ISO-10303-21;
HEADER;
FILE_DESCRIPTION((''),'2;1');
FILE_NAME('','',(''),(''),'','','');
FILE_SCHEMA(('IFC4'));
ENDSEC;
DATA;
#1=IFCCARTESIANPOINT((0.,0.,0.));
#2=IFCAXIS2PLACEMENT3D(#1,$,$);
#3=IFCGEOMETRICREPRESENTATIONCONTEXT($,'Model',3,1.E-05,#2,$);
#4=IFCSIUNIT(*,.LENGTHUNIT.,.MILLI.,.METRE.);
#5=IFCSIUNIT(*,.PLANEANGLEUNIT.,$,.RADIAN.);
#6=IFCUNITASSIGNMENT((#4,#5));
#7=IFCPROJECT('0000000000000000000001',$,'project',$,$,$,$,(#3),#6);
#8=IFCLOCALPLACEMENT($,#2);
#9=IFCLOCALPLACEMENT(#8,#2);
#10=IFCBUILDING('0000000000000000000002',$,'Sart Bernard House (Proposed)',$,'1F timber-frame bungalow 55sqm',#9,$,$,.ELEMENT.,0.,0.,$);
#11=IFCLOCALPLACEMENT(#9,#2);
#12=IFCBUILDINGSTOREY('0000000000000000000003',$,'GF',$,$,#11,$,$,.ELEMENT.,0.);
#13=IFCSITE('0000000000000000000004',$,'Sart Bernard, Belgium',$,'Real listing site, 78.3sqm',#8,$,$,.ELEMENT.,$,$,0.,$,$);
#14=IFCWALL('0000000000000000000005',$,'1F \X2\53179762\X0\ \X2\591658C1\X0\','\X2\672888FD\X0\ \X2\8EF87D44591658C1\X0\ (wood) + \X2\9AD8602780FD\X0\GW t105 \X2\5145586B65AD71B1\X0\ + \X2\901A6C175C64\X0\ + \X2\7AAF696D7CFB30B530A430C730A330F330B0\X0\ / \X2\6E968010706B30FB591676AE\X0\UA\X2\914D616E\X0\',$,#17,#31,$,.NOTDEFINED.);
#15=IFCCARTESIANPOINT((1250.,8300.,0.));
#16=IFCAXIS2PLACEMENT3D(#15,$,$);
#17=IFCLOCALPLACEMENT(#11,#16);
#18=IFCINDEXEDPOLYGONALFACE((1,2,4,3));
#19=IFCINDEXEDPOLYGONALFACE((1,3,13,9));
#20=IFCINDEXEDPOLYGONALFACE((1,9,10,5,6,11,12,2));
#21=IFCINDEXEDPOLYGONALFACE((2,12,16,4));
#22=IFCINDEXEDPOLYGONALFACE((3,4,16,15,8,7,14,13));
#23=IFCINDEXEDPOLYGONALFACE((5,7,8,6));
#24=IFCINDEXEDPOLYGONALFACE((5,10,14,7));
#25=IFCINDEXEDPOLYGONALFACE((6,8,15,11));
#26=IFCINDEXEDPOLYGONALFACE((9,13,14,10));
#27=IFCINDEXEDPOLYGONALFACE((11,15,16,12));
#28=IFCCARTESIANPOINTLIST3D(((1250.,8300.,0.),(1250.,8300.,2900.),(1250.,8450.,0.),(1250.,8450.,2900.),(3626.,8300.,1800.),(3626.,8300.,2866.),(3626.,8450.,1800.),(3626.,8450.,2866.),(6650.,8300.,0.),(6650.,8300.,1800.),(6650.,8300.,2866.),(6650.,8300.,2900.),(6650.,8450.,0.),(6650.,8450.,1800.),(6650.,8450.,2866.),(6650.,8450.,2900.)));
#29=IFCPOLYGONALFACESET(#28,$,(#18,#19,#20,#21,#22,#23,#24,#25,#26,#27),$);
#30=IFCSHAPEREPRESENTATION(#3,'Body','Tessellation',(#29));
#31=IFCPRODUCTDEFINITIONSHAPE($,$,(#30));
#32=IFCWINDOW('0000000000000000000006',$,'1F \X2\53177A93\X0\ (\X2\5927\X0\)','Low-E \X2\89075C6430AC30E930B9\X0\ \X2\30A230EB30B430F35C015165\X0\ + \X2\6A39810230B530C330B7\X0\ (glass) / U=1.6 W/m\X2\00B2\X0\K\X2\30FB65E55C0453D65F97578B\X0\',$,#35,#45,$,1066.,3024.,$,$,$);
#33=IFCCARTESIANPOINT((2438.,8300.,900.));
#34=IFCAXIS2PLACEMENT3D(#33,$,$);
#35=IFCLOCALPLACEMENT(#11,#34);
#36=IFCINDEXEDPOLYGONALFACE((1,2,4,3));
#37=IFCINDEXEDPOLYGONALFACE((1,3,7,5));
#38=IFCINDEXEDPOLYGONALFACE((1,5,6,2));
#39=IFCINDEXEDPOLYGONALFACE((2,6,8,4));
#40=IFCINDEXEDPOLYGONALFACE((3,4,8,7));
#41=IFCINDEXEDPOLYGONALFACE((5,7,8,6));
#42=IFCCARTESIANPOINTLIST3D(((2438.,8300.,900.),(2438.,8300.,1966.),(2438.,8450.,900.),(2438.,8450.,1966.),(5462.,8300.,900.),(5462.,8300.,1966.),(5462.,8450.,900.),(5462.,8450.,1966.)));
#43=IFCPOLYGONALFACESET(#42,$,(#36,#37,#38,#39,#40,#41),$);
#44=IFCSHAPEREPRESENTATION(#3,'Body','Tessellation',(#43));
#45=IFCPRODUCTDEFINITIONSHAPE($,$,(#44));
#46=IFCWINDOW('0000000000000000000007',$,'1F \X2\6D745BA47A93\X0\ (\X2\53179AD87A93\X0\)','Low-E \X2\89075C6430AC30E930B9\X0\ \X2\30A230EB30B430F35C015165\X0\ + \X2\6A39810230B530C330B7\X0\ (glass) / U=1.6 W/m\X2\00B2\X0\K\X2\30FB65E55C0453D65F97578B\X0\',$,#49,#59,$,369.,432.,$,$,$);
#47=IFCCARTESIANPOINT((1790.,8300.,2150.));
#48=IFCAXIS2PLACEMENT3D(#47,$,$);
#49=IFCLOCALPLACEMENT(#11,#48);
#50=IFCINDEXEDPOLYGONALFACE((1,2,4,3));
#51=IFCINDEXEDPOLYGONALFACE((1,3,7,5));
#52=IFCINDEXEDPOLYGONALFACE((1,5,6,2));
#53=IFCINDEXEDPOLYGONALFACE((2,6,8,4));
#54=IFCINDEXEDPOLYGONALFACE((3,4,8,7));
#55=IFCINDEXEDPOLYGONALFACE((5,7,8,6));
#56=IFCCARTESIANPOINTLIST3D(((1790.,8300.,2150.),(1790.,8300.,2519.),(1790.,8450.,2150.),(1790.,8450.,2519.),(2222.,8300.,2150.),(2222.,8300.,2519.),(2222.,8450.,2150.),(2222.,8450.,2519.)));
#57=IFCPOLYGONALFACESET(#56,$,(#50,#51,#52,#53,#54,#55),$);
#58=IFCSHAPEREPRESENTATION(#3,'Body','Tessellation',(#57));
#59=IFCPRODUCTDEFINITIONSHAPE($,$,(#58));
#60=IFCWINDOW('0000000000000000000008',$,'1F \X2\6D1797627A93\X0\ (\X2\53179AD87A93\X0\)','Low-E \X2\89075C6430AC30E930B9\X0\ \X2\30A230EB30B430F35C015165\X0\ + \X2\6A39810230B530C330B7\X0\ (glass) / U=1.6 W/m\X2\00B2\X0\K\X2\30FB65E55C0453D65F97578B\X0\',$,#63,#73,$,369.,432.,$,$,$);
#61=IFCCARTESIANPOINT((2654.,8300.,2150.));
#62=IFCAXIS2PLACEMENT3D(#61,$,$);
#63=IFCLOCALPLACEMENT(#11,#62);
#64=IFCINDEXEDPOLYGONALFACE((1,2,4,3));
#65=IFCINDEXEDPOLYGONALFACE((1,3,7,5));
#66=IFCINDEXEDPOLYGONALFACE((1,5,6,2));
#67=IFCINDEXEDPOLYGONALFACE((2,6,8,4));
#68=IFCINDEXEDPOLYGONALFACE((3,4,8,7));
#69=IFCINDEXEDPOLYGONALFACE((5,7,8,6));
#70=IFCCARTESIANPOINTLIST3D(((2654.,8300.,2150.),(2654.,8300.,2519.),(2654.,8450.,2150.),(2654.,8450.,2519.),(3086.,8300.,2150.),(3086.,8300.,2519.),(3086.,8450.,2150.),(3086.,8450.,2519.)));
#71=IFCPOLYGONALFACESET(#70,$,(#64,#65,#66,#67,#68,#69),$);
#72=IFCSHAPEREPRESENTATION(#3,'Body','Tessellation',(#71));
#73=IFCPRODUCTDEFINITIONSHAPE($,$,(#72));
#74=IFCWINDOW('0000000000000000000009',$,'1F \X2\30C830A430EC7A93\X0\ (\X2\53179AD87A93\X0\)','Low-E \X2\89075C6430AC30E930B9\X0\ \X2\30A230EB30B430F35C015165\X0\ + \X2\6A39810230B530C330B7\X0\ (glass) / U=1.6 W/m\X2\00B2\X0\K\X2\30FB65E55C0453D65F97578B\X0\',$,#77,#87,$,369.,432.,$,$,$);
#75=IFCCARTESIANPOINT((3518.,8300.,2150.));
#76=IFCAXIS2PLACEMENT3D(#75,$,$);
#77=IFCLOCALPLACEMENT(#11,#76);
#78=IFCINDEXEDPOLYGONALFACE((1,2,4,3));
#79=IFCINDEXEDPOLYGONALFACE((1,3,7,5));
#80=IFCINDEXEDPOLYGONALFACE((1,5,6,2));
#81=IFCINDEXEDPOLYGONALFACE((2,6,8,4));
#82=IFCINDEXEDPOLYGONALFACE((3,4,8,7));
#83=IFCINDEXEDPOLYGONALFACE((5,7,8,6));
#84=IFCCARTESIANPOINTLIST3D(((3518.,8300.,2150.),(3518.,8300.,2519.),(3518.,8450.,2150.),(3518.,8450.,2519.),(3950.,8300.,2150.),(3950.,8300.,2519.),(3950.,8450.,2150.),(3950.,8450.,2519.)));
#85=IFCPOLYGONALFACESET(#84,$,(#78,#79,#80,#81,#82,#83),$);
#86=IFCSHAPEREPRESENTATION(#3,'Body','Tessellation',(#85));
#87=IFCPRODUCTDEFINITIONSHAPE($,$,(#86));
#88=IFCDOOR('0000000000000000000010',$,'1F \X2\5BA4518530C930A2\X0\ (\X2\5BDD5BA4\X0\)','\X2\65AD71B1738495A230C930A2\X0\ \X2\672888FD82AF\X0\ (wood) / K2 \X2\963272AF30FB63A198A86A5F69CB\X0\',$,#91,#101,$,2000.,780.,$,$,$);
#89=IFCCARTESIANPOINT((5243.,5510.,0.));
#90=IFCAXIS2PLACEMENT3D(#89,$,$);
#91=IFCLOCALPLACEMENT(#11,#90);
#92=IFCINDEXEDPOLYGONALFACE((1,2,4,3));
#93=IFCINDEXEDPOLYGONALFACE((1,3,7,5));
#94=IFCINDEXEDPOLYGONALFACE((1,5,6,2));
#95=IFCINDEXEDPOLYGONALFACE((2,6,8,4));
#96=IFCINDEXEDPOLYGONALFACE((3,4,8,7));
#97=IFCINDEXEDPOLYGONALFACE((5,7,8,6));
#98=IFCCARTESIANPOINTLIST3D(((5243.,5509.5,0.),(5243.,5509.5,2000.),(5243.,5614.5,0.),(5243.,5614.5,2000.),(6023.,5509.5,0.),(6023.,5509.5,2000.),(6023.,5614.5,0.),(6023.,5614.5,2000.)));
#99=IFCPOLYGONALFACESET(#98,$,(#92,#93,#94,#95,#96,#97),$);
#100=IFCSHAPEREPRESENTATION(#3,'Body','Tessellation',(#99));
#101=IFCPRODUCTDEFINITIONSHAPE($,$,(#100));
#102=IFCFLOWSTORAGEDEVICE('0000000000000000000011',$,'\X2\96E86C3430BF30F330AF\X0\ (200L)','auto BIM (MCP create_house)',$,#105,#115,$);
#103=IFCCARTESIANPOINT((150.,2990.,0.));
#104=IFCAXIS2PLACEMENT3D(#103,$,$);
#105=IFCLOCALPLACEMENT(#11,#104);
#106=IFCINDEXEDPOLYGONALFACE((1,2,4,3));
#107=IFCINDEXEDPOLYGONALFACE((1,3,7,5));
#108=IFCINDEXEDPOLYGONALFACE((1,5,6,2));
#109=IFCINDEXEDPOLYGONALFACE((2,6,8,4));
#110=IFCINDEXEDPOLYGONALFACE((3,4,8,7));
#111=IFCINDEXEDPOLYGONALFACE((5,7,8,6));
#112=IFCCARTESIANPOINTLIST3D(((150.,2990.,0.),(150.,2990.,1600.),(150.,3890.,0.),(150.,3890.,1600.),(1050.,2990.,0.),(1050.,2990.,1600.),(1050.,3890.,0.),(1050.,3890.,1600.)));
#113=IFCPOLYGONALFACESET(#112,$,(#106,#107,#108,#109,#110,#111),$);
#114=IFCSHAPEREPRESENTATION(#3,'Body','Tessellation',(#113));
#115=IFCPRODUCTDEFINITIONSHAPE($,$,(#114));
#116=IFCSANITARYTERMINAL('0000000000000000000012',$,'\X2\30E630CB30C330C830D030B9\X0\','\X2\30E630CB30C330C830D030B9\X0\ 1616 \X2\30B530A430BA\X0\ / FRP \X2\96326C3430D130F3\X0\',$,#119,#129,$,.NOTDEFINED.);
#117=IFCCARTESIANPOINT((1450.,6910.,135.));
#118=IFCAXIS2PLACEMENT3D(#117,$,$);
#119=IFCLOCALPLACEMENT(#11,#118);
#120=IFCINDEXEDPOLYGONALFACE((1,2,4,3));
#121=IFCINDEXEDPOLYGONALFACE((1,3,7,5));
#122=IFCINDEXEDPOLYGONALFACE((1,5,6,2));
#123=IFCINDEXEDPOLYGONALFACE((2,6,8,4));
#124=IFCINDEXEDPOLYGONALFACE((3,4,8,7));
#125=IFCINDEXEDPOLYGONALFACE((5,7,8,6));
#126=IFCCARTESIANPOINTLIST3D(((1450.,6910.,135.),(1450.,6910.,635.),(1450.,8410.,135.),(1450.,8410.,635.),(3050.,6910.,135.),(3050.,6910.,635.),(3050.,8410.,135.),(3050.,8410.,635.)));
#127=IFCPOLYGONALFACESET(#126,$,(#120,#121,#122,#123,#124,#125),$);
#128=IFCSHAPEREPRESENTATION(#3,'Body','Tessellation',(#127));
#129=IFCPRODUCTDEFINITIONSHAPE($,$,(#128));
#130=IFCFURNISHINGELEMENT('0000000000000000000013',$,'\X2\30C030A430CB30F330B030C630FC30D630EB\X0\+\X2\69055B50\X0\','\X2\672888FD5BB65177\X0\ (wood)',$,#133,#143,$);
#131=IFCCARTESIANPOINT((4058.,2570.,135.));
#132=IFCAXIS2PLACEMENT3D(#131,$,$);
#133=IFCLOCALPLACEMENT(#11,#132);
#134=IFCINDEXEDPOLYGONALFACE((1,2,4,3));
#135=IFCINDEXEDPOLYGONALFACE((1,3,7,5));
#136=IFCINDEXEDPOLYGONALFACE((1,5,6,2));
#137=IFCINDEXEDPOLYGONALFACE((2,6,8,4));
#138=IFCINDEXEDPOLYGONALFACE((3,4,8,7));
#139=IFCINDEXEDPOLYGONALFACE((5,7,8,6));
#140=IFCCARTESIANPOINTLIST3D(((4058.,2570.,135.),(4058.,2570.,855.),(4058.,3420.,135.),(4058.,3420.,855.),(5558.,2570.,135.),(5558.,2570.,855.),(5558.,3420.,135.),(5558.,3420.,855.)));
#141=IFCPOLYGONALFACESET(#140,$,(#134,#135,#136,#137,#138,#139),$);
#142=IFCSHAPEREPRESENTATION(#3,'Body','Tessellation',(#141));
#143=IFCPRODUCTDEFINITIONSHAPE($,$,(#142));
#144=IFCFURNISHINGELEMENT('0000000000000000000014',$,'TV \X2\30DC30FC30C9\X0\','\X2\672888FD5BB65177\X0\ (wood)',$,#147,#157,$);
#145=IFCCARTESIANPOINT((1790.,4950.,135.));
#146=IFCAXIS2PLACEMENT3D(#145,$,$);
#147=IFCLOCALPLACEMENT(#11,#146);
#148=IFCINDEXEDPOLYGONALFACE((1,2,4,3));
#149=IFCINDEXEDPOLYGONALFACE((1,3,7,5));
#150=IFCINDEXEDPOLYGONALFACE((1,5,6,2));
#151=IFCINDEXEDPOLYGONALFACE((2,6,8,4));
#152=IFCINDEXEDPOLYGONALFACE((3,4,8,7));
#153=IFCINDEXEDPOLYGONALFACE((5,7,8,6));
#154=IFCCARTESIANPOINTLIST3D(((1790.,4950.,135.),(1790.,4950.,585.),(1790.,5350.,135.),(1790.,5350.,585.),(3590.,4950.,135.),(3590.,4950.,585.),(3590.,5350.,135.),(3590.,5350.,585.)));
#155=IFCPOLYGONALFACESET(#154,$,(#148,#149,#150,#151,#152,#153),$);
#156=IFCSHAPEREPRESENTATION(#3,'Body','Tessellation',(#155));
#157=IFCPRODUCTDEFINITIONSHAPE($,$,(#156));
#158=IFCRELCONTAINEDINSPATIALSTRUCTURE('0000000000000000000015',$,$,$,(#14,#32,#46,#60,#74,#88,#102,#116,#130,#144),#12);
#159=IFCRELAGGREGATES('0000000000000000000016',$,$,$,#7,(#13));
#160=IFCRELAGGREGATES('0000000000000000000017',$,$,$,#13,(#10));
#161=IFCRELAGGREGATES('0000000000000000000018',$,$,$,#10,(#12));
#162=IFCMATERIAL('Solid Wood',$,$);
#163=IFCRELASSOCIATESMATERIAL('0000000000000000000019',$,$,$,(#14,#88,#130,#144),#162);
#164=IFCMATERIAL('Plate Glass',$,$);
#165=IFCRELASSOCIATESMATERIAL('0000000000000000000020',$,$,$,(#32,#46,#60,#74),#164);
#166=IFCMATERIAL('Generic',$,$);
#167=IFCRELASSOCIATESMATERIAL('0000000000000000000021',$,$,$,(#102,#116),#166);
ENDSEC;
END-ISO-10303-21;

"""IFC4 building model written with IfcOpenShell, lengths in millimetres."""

from ifc_helpers import new_model, si_unit, frame, frame_2d, origin, place, context, project, spatial, rectangle, extrude, material, element, fill, save


model = new_model("IFC4")

# Units and contexts
model_context = context("Model", 3, precision=1e-05, world=origin())
ifc_project = project(units=[si_unit("LENGTHUNIT", "METRE", prefix="MILLI"), si_unit("PLANEANGLEUNIT", "RADIAN")], contexts=[model_context])

# Site, building, storey
site_placement = place(None, origin())
site = spatial("IfcSite", under=ifc_project, at=site_placement, Name="Sart Bernard, Belgium", ObjectType="Real listing site, 78.3sqm", CompositionType="ELEMENT", RefElevation=0.0)
building_placement = place(site_placement, origin())
building = spatial("IfcBuilding", under=site, at=building_placement, Name="Sart Bernard House (Proposed)", ObjectType="1F timber-frame bungalow 55sqm", CompositionType="ELEMENT", ElevationOfRefHeight=0.0, ElevationOfTerrain=0.0)
storey_placement = place(building_placement, origin())
storey = spatial("IfcBuildingStorey", under=building, at=storey_placement, Name="GF", CompositionType="ELEMENT", Elevation=0.0)

# Wall, openings, windows
ifc_material_1 = material(Name="Solid Wood")
wall_1_placement = place(storey_placement, frame((1250.0, 8300.0, 0.0)))
wall_1 = element("IfcWall", 1, at=wall_1_placement, inside=storey, material=ifc_material_1, Name="1F 北面 外壁", Description="木製 軸組外壁 (wood) + 高性能GW t105 充填断熱 + 通気層 + 窯業系サイディング / 準耐火・外皮UA配慮", PredefinedType="NOTDEFINED", context=model_context, shape_type="SweptSolid", body=[
    extrude(rectangle(XDim=5400.0, YDim=150.0, at=frame_2d((2700.0, 75.0))), frame((1250.0, 8300.0, 0.0)), (0.0, 0.0, 1.0), 2900.0),
])
opening_1_placement = place(storey_placement, frame((2438.0, 8300.0, 900.0)))
opening_1 = element("IfcOpeningElement", 2, at=opening_1_placement, cuts=wall_1, PredefinedType="NOTDEFINED", context=model_context, shape_type="SweptSolid", body=[
    extrude(rectangle(XDim=3024.0, YDim=150.0, at=frame_2d((1512.0, 75.0))), frame((2438.0, 8300.0, 900.0)), (0.0, 0.0, 1.0), 1066.0),
])
opening_2_placement = place(storey_placement, frame((1790.0, 8300.0, 2150.0)))
opening_2 = element("IfcOpeningElement", 3, at=opening_2_placement, cuts=wall_1, PredefinedType="NOTDEFINED", context=model_context, shape_type="SweptSolid", body=[
    extrude(rectangle(XDim=432.0, YDim=150.0, at=frame_2d((216.0, 75.0))), frame((1790.0, 8300.0, 2150.0)), (0.0, 0.0, 1.0), 369.0),
])
opening_3_placement = place(storey_placement, frame((2654.0, 8300.0, 2150.0)))
opening_3 = element("IfcOpeningElement", 4, at=opening_3_placement, cuts=wall_1, PredefinedType="NOTDEFINED", context=model_context, shape_type="SweptSolid", body=[
    extrude(rectangle(XDim=432.0, YDim=150.0, at=frame_2d((216.0, 75.0))), frame((2654.0, 8300.0, 2150.0)), (0.0, 0.0, 1.0), 369.0),
])
opening_4_placement = place(storey_placement, frame((3518.0, 8300.0, 2150.0)))
opening_4 = element("IfcOpeningElement", 5, at=opening_4_placement, cuts=wall_1, PredefinedType="NOTDEFINED", context=model_context, shape_type="SweptSolid", body=[
    extrude(rectangle(XDim=432.0, YDim=150.0, at=frame_2d((216.0, 75.0))), frame((3518.0, 8300.0, 2150.0)), (0.0, 0.0, 1.0), 369.0),
])
ifc_material_2 = material(Name="Plate Glass")
window_1_placement = place(storey_placement, frame((2438.0, 8300.0, 900.0)))
window_1 = element("IfcWindow", 6, at=window_1_placement, inside=storey, material=ifc_material_2, Name="1F 北窓 (大)", Description="Low-E 複層ガラス アルゴン封入 + 樹脂サッシ (glass) / U=1.6 W/m²K・日射取得型", OverallHeight=1066.0, OverallWidth=3024.0, context=model_context, shape_type="SweptSolid", body=[
    extrude(rectangle(XDim=3024.0, YDim=150.0, at=frame_2d((1512.0, 75.0))), frame((2438.0, 8300.0, 900.0)), (0.0, 0.0, 1.0), 1066.0),
])
fill(opening_1, window_1)
window_2_placement = place(storey_placement, frame((1790.0, 8300.0, 2150.0)))
window_2 = element("IfcWindow", 7, at=window_2_placement, inside=storey, material=ifc_material_2, Name="1F 浴室窓 (北高窓)", Description="Low-E 複層ガラス アルゴン封入 + 樹脂サッシ (glass) / U=1.6 W/m²K・日射取得型", OverallHeight=369.0, OverallWidth=432.0, context=model_context, shape_type="SweptSolid", body=[
    extrude(rectangle(XDim=432.0, YDim=150.0, at=frame_2d((216.0, 75.0))), frame((1790.0, 8300.0, 2150.0)), (0.0, 0.0, 1.0), 369.0),
])
fill(opening_2, window_2)
window_3_placement = place(storey_placement, frame((2654.0, 8300.0, 2150.0)))
window_3 = element("IfcWindow", 8, at=window_3_placement, inside=storey, material=ifc_material_2, Name="1F 洗面窓 (北高窓)", Description="Low-E 複層ガラス アルゴン封入 + 樹脂サッシ (glass) / U=1.6 W/m²K・日射取得型", OverallHeight=369.0, OverallWidth=432.0, context=model_context, shape_type="SweptSolid", body=[
    extrude(rectangle(XDim=432.0, YDim=150.0, at=frame_2d((216.0, 75.0))), frame((2654.0, 8300.0, 2150.0)), (0.0, 0.0, 1.0), 369.0),
])
fill(opening_3, window_3)
window_4_placement = place(storey_placement, frame((3518.0, 8300.0, 2150.0)))
window_4 = element("IfcWindow", 9, at=window_4_placement, inside=storey, material=ifc_material_2, Name="1F トイレ窓 (北高窓)", Description="Low-E 複層ガラス アルゴン封入 + 樹脂サッシ (glass) / U=1.6 W/m²K・日射取得型", OverallHeight=369.0, OverallWidth=432.0, context=model_context, shape_type="SweptSolid", body=[
    extrude(rectangle(XDim=432.0, YDim=150.0, at=frame_2d((216.0, 75.0))), frame((3518.0, 8300.0, 2150.0)), (0.0, 0.0, 1.0), 369.0),
])
fill(opening_4, window_4)

# Door
door_1_placement = place(storey_placement, frame((5243.0, 5510.0, 0.0)))
element("IfcDoor", 10, at=door_1_placement, inside=storey, material=ifc_material_1, Name="1F 室内ドア (寝室)", Description="断熱玄関ドア 木製芯 (wood) / K2 防犯・採風機構", OverallHeight=2000.0, OverallWidth=780.0, context=model_context, shape_type="SweptSolid", body=[
    extrude(rectangle(XDim=780.0, YDim=105.0, at=frame_2d((390.0, 52.0))), frame((5243.0, 5510.0, 0.0)), (0.0, 0.0, 1.0), 2000.0),
])

# Flow storage device
ifc_material_3 = material(Name="Generic")
flow_storage_device_placement = place(storey_placement, frame((150.0, 2990.0, 0.0)))
element("IfcFlowStorageDevice", 11, at=flow_storage_device_placement, inside=storey, material=ifc_material_3, Name="雨水タンク (200L)", Description="auto BIM (MCP create_house)", context=model_context, shape_type="SweptSolid", body=[
    extrude(rectangle(XDim=900.0, YDim=900.0, at=frame_2d((450.0, 450.0))), frame((150.0, 2990.0, 0.0)), (0.0, 0.0, 1.0), 1600.0),
])

# Sanitary terminal
sanitary_terminal_placement = place(storey_placement, frame((1450.0, 6910.0, 135.0)))
element("IfcSanitaryTerminal", 12, at=sanitary_terminal_placement, inside=storey, material=ifc_material_3, Name="ユニットバス", Description="ユニットバス 1616 サイズ / FRP 防水パン", PredefinedType="NOTDEFINED", context=model_context, shape_type="SweptSolid", body=[
    extrude(rectangle(XDim=1600.0, YDim=1500.0, at=frame_2d((800.0, 750.0))), frame((1450.0, 6910.0, 135.0)), (0.0, 0.0, 1.0), 500.0),
])

# Furnishing elements
furnishing_1_placement = place(storey_placement, frame((4058.0, 2570.0, 135.0)))
element("IfcFurnishingElement", 13, at=furnishing_1_placement, inside=storey, material=ifc_material_1, Name="ダイニングテーブル+椅子", Description="木製家具 (wood)", context=model_context, shape_type="SweptSolid", body=[
    extrude(rectangle(XDim=1500.0, YDim=850.0, at=frame_2d((750.0, 425.0))), frame((4058.0, 2570.0, 135.0)), (0.0, 0.0, 1.0), 720.0),
])
furnishing_2_placement = place(storey_placement, frame((1790.0, 4950.0, 135.0)))
element("IfcFurnishingElement", 14, at=furnishing_2_placement, inside=storey, material=ifc_material_1, Name="TV ボード", Description="木製家具 (wood)", context=model_context, shape_type="SweptSolid", body=[
    extrude(rectangle(XDim=1800.0, YDim=400.0, at=frame_2d((900.0, 200.0))), frame((1790.0, 4950.0, 135.0)), (0.0, 0.0, 1.0), 450.0),
])

save(model, "model.ifc")
